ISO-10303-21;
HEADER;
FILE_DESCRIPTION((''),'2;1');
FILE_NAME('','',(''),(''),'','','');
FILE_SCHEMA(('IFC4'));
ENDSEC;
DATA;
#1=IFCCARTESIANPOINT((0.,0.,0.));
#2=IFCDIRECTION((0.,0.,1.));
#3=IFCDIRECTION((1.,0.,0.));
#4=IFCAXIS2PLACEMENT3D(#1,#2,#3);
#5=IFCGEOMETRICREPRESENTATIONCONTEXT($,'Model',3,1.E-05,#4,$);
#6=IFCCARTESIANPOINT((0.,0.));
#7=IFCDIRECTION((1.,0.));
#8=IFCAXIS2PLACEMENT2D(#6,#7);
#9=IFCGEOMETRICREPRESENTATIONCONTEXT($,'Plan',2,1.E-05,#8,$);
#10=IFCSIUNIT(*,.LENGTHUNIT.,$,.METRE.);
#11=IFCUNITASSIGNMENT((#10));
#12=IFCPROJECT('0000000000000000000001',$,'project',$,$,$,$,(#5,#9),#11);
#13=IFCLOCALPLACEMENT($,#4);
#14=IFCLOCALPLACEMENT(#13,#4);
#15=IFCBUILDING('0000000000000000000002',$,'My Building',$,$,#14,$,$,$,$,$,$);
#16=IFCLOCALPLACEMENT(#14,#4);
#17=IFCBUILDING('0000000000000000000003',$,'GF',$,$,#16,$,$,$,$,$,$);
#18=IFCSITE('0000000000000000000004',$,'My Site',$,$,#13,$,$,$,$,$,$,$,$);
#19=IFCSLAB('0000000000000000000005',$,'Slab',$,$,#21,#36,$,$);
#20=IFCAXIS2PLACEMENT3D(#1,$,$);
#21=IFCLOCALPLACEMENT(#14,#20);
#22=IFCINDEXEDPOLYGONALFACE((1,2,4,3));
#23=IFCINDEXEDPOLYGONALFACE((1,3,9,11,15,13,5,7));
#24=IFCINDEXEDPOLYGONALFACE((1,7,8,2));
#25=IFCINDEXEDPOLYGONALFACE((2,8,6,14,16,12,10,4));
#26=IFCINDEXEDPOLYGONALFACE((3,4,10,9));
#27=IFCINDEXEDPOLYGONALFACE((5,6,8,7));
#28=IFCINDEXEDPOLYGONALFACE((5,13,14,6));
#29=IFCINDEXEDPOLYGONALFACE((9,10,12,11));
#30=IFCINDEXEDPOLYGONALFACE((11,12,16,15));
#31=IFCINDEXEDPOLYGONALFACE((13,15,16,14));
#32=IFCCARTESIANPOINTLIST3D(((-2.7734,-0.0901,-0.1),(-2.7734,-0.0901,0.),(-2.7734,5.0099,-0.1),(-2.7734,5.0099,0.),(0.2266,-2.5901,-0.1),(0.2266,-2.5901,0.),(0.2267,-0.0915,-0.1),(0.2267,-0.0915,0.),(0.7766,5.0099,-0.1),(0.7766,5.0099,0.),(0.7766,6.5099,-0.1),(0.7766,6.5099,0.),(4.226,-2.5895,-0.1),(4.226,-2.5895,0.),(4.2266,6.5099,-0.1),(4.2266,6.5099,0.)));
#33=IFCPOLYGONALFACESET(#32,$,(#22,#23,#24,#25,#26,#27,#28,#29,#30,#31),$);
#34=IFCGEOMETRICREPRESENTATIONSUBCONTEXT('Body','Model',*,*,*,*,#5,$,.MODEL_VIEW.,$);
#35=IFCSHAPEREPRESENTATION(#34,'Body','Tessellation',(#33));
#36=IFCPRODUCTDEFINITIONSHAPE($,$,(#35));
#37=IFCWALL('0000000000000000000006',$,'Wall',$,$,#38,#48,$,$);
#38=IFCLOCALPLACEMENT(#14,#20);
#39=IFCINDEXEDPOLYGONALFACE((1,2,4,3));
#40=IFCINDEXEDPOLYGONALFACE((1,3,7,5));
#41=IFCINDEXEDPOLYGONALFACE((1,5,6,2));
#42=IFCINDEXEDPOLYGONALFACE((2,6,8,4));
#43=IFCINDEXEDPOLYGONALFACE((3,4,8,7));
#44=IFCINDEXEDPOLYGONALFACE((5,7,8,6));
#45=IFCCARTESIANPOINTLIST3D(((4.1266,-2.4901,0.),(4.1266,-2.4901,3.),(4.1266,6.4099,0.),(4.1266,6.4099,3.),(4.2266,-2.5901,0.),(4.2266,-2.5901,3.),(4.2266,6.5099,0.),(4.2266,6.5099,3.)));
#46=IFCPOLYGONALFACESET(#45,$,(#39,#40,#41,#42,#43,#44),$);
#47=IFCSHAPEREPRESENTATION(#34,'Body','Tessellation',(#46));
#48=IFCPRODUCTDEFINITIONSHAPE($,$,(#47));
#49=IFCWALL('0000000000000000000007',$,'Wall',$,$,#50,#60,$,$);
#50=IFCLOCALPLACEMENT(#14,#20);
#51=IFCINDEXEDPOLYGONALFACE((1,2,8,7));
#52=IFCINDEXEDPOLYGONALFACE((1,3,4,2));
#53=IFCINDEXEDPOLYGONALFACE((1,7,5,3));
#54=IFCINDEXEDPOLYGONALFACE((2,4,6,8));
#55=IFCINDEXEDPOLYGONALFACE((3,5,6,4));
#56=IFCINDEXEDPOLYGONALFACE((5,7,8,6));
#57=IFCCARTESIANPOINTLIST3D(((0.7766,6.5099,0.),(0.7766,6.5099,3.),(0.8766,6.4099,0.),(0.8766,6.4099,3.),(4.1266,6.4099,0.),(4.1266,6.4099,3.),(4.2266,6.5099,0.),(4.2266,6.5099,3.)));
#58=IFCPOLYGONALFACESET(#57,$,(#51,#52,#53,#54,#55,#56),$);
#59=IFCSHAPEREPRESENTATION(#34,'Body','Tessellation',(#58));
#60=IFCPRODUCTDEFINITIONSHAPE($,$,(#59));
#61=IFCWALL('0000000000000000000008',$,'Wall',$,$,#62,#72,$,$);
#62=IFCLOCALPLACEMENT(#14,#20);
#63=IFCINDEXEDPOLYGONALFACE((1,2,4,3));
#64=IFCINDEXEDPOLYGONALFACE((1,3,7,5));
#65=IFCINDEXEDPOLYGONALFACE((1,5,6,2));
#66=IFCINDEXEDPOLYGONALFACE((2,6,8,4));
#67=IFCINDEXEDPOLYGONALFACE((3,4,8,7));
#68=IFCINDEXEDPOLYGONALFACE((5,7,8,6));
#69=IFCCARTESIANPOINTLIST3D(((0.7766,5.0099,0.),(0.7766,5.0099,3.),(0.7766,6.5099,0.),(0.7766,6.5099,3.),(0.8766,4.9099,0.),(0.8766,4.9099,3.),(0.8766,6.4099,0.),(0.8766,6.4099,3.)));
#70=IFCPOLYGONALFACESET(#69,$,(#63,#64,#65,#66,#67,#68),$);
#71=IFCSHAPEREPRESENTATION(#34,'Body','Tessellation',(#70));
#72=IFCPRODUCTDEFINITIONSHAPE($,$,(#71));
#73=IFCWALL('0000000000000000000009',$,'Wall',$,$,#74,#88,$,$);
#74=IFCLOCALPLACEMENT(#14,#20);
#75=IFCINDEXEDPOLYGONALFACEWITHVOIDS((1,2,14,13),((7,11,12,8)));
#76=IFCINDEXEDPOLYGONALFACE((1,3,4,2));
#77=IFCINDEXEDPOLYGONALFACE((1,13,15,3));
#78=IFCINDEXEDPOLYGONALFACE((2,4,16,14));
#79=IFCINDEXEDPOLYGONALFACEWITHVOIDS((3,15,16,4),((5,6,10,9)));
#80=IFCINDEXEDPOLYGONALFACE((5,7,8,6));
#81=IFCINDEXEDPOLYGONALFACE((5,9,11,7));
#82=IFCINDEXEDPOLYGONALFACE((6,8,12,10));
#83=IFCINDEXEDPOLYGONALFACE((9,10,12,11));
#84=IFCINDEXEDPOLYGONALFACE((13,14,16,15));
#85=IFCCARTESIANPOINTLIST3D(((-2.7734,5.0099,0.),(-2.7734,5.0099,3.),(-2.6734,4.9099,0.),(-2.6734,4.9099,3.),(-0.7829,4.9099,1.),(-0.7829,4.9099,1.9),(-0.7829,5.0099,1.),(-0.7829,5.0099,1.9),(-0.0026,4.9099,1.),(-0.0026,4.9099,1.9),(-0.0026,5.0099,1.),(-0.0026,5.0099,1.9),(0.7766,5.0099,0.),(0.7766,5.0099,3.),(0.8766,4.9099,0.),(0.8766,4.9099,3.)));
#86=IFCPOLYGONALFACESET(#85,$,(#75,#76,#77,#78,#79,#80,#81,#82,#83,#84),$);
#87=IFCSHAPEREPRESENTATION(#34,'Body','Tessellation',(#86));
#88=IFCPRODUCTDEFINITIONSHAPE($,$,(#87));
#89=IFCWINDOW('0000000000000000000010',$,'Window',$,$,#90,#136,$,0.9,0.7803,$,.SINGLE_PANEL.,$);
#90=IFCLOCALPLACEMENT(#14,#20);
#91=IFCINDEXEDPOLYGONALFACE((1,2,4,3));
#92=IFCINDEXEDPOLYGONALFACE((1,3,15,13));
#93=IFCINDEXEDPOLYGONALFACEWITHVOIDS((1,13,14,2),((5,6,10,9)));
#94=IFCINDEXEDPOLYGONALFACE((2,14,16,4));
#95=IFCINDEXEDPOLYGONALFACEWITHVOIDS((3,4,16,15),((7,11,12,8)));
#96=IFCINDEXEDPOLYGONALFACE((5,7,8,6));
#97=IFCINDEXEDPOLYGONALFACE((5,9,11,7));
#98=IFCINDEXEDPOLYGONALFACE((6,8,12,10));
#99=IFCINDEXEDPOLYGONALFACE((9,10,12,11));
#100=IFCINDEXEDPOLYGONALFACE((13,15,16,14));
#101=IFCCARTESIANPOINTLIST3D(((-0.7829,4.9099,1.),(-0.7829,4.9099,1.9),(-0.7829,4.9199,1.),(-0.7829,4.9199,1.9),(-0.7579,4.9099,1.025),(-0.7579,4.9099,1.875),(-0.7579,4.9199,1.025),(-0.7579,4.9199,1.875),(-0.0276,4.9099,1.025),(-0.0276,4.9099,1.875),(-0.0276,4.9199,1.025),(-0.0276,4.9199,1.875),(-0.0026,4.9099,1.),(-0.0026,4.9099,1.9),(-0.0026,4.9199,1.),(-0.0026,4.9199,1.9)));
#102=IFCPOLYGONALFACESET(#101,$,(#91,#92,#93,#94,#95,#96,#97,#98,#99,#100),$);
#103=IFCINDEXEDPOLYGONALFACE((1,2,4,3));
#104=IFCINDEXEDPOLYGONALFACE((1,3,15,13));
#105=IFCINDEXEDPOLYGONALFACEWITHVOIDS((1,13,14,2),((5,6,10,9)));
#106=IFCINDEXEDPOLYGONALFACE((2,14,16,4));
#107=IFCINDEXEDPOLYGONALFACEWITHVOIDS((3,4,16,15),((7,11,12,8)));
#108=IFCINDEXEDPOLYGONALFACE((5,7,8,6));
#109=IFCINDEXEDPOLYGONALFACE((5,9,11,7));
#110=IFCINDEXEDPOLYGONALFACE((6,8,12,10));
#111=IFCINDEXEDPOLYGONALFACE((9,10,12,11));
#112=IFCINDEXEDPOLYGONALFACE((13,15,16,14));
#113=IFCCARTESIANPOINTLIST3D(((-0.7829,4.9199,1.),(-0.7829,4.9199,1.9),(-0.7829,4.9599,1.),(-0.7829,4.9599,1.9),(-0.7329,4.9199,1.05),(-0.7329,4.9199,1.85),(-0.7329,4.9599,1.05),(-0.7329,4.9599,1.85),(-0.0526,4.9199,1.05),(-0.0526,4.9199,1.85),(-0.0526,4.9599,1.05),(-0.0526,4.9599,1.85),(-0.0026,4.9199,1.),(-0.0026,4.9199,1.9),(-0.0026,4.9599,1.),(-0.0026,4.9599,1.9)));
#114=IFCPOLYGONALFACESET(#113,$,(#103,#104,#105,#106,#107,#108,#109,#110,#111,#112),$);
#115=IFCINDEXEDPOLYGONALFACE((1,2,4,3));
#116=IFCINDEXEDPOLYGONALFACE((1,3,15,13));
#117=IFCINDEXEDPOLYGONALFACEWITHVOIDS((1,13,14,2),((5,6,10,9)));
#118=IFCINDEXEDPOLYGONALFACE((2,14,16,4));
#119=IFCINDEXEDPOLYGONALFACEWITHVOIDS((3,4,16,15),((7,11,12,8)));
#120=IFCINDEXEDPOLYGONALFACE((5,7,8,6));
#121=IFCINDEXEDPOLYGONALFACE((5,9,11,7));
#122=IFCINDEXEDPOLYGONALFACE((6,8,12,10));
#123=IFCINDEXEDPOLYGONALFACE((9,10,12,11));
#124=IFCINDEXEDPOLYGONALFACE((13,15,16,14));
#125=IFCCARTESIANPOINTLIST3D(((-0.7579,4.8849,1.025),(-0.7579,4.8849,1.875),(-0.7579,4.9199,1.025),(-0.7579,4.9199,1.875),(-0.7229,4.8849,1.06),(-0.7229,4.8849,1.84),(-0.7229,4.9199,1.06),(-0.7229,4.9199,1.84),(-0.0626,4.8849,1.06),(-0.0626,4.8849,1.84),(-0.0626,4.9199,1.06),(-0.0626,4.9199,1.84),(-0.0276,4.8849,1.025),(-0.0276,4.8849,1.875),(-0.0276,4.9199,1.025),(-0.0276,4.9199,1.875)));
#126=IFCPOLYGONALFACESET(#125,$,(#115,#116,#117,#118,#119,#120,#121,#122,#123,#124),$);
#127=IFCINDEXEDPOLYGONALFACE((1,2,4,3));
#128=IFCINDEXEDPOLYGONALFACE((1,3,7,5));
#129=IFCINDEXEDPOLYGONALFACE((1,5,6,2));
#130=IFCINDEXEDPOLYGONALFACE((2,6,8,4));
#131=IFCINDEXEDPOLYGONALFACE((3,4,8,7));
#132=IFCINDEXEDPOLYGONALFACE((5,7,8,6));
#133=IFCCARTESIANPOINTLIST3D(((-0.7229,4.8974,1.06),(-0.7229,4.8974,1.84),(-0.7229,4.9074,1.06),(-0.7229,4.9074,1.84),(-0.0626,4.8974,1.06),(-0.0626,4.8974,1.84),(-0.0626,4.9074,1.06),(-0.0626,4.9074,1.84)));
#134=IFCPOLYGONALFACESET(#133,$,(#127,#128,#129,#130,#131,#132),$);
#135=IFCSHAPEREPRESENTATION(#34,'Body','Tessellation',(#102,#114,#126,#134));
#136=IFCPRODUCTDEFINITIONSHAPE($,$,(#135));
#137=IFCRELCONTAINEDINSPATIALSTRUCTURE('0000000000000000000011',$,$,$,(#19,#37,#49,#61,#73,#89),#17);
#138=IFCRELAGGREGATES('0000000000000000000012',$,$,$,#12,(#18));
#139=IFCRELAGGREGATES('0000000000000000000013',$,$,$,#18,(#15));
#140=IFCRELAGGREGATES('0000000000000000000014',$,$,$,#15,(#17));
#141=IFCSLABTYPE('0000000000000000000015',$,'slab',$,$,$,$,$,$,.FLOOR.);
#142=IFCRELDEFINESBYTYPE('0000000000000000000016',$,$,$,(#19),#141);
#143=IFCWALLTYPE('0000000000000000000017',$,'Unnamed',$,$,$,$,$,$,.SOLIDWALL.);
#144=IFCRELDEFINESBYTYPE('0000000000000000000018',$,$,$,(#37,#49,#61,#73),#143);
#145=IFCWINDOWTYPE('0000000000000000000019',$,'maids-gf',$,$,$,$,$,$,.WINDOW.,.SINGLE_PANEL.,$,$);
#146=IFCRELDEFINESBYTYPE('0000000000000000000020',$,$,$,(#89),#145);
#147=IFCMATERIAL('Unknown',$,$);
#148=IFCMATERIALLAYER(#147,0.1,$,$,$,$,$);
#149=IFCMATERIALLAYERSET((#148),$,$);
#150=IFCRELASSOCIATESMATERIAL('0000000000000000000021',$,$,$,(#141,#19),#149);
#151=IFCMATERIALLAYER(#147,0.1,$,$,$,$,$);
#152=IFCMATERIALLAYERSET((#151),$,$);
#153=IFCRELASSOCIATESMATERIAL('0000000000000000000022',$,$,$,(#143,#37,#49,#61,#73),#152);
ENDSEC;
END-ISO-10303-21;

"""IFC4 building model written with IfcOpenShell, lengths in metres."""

from ifc_helpers import new_model, entity, si_unit, frame, origin_with_axes, origin_2d_with_axis, place, context, subcontext, project, spatial, line, indexed_curve, outline, extrude, shape, source, transform, mapped, material, layer, layer_set, layer_usage, type_object, type_shapes, element, fill, save


model = new_model("IFC4")

# Units and contexts
model_context = context("Model", 3, precision=1e-05, world=origin_with_axes())
plan_context = context("Plan", 2, precision=1e-05, world=origin_2d_with_axis())
body_context_1 = subcontext(model_context, "Body", "Model", "MODEL_VIEW")
body_context_2 = subcontext(plan_context, "Body", "Plan", "PLAN_VIEW")
ifc_project = project(units=[si_unit("LENGTHUNIT", "METRE")], contexts=[model_context, plan_context])

# Site, buildings
site_placement = place(None, origin_with_axes())
site = spatial("IfcSite", under=ifc_project, at=site_placement, Name="My Site")
building_1_placement = place(site_placement, origin_with_axes())
building_1 = spatial("IfcBuilding", under=site, at=building_1_placement, Name="My Building")
building_2_placement = place(building_1_placement, origin_with_axes())
building_2 = spatial("IfcBuilding", under=building_1, at=building_2_placement, Name="GF")

# Slab
ifc_material = material(Name="Unknown")
ifc_layer_1 = layer(ifc_material, 0.1)
ifc_layer_set_1 = layer_set([ifc_layer_1])
ifc_layer_usage_1 = layer_usage(ifc_layer_set_1, "AXIS3", "POSITIVE", -0.1)
slab_type = type_object("IfcSlabType", Name="slab", PredefinedType="FLOOR", material=ifc_layer_set_1)
slab_placement = place(building_2_placement, frame((4.2266, 6.5099, 0.0), z_axis=(0.0, 0.0, 1.0), x_axis=(1.0, 0.0, 0.0)))
element("IfcSlab", 1, at=slab_placement, inside=building_2, type_object=slab_type, material=ifc_layer_usage_1, Name="Slab", context=body_context_1, shape_type="SweptSolid", body=[
    extrude(outline(indexed_curve([(0.0, 0.0), (-3.45, 0.0), (-3.45, -1.5), (-7.0, -1.5), (-7.0, -6.6), (-3.9999, -6.6014), (-4.0, -9.1), (-0.0006, -9.0994), (0.0, 0.0)])), frame((0.0, 0.0, -0.1), z_axis=(0.0, 0.0, 1.0), x_axis=(1.0, 0.0, 0.0)), (0.0, 0.0, 1.0), 0.1),
])

# Shared definitions
ifc_layer_2 = layer(ifc_material, 0.1)
ifc_layer_set_2 = layer_set([ifc_layer_2])
wall_type = type_object("IfcWallType", Name="Unnamed", PredefinedType="SOLIDWALL", material=ifc_layer_set_2)

# Walls
ifc_layer_usage_2 = layer_usage(ifc_layer_set_2, "AXIS2", "POSITIVE", 0.0)
wall_1_placement = place(building_2_placement, frame((4.2266, -2.5901, 0.0), z_axis=(0.0, 0.0, 1.0), x_axis=(0.0, 1.0, 0.0)))
element("IfcWall", 2, at=wall_1_placement, inside=building_2, type_object=wall_type, material=ifc_layer_usage_2, Name="Wall", context=body_context_1, shape_type="SweptSolid", body=[
    extrude(outline(indexed_curve([(0.0, 0.0), (0.1, 0.1), (9.0, 0.1), (9.1, 0.0)], segments=[line(1, 2, 3, 4, 1)])), origin_with_axes(), (0.0, 0.0, 1.0), 3.0),
])
ifc_layer_usage_3 = layer_usage(ifc_layer_set_2, "AXIS2", "POSITIVE", 0.0)
wall_2_placement = place(building_2_placement, frame((4.2266, 6.5099, 0.0), z_axis=(0.0, 0.0, 1.0), x_axis=(-1.0, 0.0, 0.0)))
element("IfcWall", 3, at=wall_2_placement, inside=building_2, type_object=wall_type, material=ifc_layer_usage_3, Name="Wall", context=body_context_1, shape_type="SweptSolid", body=[
    extrude(outline(indexed_curve([(0.0, 0.0), (0.1, 0.1), (3.35, 0.1), (3.45, 0.0)], segments=[line(1, 2, 3, 4, 1)])), origin_with_axes(), (0.0, 0.0, 1.0), 3.0),
])
ifc_layer_usage_4 = layer_usage(ifc_layer_set_2, "AXIS2", "POSITIVE", 0.0)
wall_3_placement = place(building_2_placement, frame((0.7766, 6.5099, 0.0), z_axis=(0.0, 0.0, 1.0), x_axis=(0.0, -1.0, 0.0)))
element("IfcWall", 4, at=wall_3_placement, inside=building_2, type_object=wall_type, material=ifc_layer_usage_4, Name="Wall", context=body_context_1, shape_type="SweptSolid", body=[
    extrude(outline(indexed_curve([(0.0, 0.0), (0.1, 0.1), (1.6, 0.1), (1.5, 0.0)], segments=[line(1, 2, 3, 4, 1)])), origin_with_axes(), (0.0, 0.0, 1.0), 3.0),
])

# Wall, opening, window
ifc_layer_usage_5 = layer_usage(ifc_layer_set_2, "AXIS2", "POSITIVE", 0.0)
wall_4_placement = place(building_2_placement, frame((0.7766, 5.0099, 0.0), z_axis=(0.0, 0.0, 1.0), x_axis=(-1.0, 0.0, 0.0)))
wall_4 = element("IfcWall", 5, at=wall_4_placement, inside=building_2, type_object=wall_type, material=ifc_layer_usage_5, Name="Wall", context=body_context_1, shape_type="SweptSolid", body=[
    extrude(outline(indexed_curve([(0.0, 0.0), (-0.1, 0.1), (3.45, 0.1), (3.55, 0.0)], segments=[line(1, 2, 3, 4, 1)])), origin_with_axes(), (0.0, 0.0, 1.0), 3.0),
])
shared_shape_1 = source(origin_with_axes(), body_context_1, "Body", "SweptSolid", [
    extrude(outline(indexed_curve([(0.0, 0.0), (0.7803, 0.0), (0.7803, 0.9), (0.0, 0.9)], segments=[line(1, 2, 3, 4, 1)])), frame((0.0, -0.6, 0.0), z_axis=(0.0, -1.0, 0.0), x_axis=(1.0, 0.0, 0.0)), (0.0, 0.0, -1.0), 1.2),
])
opening_1_placement = place(wall_4_placement, frame((0.7792, 0.0, 1.0), z_axis=(0.0, 0.0, 1.0), x_axis=(1.0, 0.0, 0.0)))
opening_1 = element("IfcOpeningElement", 6, at=opening_1_placement, cuts=wall_4, PredefinedType="OPENING", context=body_context_1, shape_type="MappedRepresentation", body=[
    mapped(shared_shape_1, transform((0.0, 0.0, 0.0), x_axis=(1.0, 0.0, 0.0), y_axis=(0.0, 1.0, 0.0), z_axis=(0.0, 0.0, 1.0), scale=1.0)),
])
window_type_1 = type_object("IfcWindowType", Name="maids-gf", PartitioningType="SINGLE_PANEL", PredefinedType="WINDOW")
shared_shape_2 = source(origin_with_axes(), body_context_1, "Body", "SweptSolid", [
    extrude(outline(indexed_curve([(0.0, 0.0), (0.7803, 0.0), (0.7803, 0.9), (0.0, 0.9)], segments=[line(1, 2, 3, 4, 1)]), holes=[indexed_curve([(0.025, 0.025), (0.7553, 0.025), (0.7553, 0.875), (0.025, 0.875)], segments=[line(1, 2, 3, 4, 1)])]), frame((0.0, 0.09, 0.0), z_axis=(0.0, -1.0, 0.0), x_axis=(1.0, 0.0, 0.0)), (0.0, 0.0, -1.0), 0.01),
    extrude(outline(indexed_curve([(0.0, 0.0), (0.7803, 0.0), (0.7803, 0.9), (0.0, 0.9)], segments=[line(1, 2, 3, 4, 1)]), holes=[indexed_curve([(0.05, 0.05), (0.7303, 0.05), (0.7303, 0.85), (0.05, 0.85)], segments=[line(1, 2, 3, 4, 1)])]), frame((0.0, 0.05, 0.0), z_axis=(0.0, -1.0, 0.0), x_axis=(1.0, 0.0, 0.0)), (0.0, 0.0, -1.0), 0.04),
    extrude(outline(indexed_curve([(0.0, 0.0), (0.7303, 0.0), (0.7303, 0.85), (0.0, 0.85)], segments=[line(1, 2, 3, 4, 1)]), holes=[indexed_curve([(0.035, 0.035), (0.6953, 0.035), (0.6953, 0.815), (0.035, 0.815)], segments=[line(1, 2, 3, 4, 1)])]), frame((0.025, 0.09, 0.025), z_axis=(0.0, -1.0, 0.0), x_axis=(1.0, 0.0, 0.0)), (0.0, 0.0, -1.0), 0.035),
    extrude(outline(indexed_curve([(0.035, 0.035), (0.6953, 0.035), (0.6953, 0.815), (0.035, 0.815)], segments=[line(1, 2, 3, 4, 1)])), frame((0.025, 0.1025, 0.025), z_axis=(0.0, -1.0, 0.0), x_axis=(1.0, 0.0, 0.0)), (0.0, 0.0, -1.0), 0.01),
])
shared_shape_3 = source(origin_with_axes(), body_context_2, "Body", "Curve2D", [
    entity("IfcIndexedPolyCurve", entity("IfcCartesianPointList2D", [[0.05, 0.05], [0.7303, 0.05]])),
    entity("IfcIndexedPolyCurve", entity("IfcCartesianPointList2D", [[0.0, 0.1], [0.025, 0.1], [0.025, 0.09], [0.05, 0.09], [0.05, 0.05], [0.0, 0.05]]), [entity("IfcLineIndex", [1, 2, 3, 4, 5, 6, 1])]),
    entity("IfcIndexedPolyCurve", entity("IfcCartesianPointList2D", [[0.7803, 0.1], [0.7553, 0.1], [0.7553, 0.09], [0.7303, 0.09], [0.7303, 0.05], [0.7803, 0.05]]), [entity("IfcLineIndex", [1, 2, 3, 4, 5, 6, 1])]),
    entity("IfcIndexedPolyCurve", entity("IfcCartesianPointList2D", [[0.025, 0.09], [0.06, 0.09], [0.06, 0.125], [0.025, 0.125]]), [entity("IfcLineIndex", [1, 2, 3, 4, 1])]),
    entity("IfcIndexedPolyCurve", entity("IfcCartesianPointList2D", [[0.7553, 0.09], [0.7203, 0.09], [0.7203, 0.125], [0.7553, 0.125]]), [entity("IfcLineIndex", [1, 2, 3, 4, 1])]),
    entity("IfcIndexedPolyCurve", entity("IfcCartesianPointList2D", [[0.06, 0.09], [0.7203, 0.09]])),
    entity("IfcIndexedPolyCurve", entity("IfcCartesianPointList2D", [[0.06, 0.125], [0.7203, 0.125]])),
    entity("IfcIndexedPolyCurve", entity("IfcCartesianPointList2D", [[0.06, 0.1075], [0.7203, 0.1075]])),
])
type_shapes(window_type_1, [shared_shape_2, shared_shape_3])
window_1_placement = place(opening_1_placement, frame((0.0, 0.0, 0.0), z_axis=(0.0, 0.0, 1.0), x_axis=(1.0, 0.0, 0.0)))
window_1 = element("IfcWindow", 7, at=window_1_placement, inside=building_2, type_object=window_type_1, Name="Window", OverallHeight=0.9, OverallWidth=0.7803, PartitioningType="SINGLE_PANEL", shapes=[
    shape(body_context_1, "Body", "MappedRepresentation", [mapped(shared_shape_2, transform((0.0, 0.0, 0.0), x_axis=(1.0, 0.0, 0.0), y_axis=(0.0, 1.0, 0.0), z_axis=(0.0, 0.0, 1.0), scale=1.0))]),
    shape(body_context_2, "Body", "MappedRepresentation", [mapped(shared_shape_3, transform((0.0, 0.0, 0.0), x_axis=(1.0, 0.0, 0.0), y_axis=(0.0, 1.0, 0.0), z_axis=(0.0, 0.0, 1.0), scale=1.0))]),
])
fill(opening_1, window_1)

save(model, "model.ifc")
